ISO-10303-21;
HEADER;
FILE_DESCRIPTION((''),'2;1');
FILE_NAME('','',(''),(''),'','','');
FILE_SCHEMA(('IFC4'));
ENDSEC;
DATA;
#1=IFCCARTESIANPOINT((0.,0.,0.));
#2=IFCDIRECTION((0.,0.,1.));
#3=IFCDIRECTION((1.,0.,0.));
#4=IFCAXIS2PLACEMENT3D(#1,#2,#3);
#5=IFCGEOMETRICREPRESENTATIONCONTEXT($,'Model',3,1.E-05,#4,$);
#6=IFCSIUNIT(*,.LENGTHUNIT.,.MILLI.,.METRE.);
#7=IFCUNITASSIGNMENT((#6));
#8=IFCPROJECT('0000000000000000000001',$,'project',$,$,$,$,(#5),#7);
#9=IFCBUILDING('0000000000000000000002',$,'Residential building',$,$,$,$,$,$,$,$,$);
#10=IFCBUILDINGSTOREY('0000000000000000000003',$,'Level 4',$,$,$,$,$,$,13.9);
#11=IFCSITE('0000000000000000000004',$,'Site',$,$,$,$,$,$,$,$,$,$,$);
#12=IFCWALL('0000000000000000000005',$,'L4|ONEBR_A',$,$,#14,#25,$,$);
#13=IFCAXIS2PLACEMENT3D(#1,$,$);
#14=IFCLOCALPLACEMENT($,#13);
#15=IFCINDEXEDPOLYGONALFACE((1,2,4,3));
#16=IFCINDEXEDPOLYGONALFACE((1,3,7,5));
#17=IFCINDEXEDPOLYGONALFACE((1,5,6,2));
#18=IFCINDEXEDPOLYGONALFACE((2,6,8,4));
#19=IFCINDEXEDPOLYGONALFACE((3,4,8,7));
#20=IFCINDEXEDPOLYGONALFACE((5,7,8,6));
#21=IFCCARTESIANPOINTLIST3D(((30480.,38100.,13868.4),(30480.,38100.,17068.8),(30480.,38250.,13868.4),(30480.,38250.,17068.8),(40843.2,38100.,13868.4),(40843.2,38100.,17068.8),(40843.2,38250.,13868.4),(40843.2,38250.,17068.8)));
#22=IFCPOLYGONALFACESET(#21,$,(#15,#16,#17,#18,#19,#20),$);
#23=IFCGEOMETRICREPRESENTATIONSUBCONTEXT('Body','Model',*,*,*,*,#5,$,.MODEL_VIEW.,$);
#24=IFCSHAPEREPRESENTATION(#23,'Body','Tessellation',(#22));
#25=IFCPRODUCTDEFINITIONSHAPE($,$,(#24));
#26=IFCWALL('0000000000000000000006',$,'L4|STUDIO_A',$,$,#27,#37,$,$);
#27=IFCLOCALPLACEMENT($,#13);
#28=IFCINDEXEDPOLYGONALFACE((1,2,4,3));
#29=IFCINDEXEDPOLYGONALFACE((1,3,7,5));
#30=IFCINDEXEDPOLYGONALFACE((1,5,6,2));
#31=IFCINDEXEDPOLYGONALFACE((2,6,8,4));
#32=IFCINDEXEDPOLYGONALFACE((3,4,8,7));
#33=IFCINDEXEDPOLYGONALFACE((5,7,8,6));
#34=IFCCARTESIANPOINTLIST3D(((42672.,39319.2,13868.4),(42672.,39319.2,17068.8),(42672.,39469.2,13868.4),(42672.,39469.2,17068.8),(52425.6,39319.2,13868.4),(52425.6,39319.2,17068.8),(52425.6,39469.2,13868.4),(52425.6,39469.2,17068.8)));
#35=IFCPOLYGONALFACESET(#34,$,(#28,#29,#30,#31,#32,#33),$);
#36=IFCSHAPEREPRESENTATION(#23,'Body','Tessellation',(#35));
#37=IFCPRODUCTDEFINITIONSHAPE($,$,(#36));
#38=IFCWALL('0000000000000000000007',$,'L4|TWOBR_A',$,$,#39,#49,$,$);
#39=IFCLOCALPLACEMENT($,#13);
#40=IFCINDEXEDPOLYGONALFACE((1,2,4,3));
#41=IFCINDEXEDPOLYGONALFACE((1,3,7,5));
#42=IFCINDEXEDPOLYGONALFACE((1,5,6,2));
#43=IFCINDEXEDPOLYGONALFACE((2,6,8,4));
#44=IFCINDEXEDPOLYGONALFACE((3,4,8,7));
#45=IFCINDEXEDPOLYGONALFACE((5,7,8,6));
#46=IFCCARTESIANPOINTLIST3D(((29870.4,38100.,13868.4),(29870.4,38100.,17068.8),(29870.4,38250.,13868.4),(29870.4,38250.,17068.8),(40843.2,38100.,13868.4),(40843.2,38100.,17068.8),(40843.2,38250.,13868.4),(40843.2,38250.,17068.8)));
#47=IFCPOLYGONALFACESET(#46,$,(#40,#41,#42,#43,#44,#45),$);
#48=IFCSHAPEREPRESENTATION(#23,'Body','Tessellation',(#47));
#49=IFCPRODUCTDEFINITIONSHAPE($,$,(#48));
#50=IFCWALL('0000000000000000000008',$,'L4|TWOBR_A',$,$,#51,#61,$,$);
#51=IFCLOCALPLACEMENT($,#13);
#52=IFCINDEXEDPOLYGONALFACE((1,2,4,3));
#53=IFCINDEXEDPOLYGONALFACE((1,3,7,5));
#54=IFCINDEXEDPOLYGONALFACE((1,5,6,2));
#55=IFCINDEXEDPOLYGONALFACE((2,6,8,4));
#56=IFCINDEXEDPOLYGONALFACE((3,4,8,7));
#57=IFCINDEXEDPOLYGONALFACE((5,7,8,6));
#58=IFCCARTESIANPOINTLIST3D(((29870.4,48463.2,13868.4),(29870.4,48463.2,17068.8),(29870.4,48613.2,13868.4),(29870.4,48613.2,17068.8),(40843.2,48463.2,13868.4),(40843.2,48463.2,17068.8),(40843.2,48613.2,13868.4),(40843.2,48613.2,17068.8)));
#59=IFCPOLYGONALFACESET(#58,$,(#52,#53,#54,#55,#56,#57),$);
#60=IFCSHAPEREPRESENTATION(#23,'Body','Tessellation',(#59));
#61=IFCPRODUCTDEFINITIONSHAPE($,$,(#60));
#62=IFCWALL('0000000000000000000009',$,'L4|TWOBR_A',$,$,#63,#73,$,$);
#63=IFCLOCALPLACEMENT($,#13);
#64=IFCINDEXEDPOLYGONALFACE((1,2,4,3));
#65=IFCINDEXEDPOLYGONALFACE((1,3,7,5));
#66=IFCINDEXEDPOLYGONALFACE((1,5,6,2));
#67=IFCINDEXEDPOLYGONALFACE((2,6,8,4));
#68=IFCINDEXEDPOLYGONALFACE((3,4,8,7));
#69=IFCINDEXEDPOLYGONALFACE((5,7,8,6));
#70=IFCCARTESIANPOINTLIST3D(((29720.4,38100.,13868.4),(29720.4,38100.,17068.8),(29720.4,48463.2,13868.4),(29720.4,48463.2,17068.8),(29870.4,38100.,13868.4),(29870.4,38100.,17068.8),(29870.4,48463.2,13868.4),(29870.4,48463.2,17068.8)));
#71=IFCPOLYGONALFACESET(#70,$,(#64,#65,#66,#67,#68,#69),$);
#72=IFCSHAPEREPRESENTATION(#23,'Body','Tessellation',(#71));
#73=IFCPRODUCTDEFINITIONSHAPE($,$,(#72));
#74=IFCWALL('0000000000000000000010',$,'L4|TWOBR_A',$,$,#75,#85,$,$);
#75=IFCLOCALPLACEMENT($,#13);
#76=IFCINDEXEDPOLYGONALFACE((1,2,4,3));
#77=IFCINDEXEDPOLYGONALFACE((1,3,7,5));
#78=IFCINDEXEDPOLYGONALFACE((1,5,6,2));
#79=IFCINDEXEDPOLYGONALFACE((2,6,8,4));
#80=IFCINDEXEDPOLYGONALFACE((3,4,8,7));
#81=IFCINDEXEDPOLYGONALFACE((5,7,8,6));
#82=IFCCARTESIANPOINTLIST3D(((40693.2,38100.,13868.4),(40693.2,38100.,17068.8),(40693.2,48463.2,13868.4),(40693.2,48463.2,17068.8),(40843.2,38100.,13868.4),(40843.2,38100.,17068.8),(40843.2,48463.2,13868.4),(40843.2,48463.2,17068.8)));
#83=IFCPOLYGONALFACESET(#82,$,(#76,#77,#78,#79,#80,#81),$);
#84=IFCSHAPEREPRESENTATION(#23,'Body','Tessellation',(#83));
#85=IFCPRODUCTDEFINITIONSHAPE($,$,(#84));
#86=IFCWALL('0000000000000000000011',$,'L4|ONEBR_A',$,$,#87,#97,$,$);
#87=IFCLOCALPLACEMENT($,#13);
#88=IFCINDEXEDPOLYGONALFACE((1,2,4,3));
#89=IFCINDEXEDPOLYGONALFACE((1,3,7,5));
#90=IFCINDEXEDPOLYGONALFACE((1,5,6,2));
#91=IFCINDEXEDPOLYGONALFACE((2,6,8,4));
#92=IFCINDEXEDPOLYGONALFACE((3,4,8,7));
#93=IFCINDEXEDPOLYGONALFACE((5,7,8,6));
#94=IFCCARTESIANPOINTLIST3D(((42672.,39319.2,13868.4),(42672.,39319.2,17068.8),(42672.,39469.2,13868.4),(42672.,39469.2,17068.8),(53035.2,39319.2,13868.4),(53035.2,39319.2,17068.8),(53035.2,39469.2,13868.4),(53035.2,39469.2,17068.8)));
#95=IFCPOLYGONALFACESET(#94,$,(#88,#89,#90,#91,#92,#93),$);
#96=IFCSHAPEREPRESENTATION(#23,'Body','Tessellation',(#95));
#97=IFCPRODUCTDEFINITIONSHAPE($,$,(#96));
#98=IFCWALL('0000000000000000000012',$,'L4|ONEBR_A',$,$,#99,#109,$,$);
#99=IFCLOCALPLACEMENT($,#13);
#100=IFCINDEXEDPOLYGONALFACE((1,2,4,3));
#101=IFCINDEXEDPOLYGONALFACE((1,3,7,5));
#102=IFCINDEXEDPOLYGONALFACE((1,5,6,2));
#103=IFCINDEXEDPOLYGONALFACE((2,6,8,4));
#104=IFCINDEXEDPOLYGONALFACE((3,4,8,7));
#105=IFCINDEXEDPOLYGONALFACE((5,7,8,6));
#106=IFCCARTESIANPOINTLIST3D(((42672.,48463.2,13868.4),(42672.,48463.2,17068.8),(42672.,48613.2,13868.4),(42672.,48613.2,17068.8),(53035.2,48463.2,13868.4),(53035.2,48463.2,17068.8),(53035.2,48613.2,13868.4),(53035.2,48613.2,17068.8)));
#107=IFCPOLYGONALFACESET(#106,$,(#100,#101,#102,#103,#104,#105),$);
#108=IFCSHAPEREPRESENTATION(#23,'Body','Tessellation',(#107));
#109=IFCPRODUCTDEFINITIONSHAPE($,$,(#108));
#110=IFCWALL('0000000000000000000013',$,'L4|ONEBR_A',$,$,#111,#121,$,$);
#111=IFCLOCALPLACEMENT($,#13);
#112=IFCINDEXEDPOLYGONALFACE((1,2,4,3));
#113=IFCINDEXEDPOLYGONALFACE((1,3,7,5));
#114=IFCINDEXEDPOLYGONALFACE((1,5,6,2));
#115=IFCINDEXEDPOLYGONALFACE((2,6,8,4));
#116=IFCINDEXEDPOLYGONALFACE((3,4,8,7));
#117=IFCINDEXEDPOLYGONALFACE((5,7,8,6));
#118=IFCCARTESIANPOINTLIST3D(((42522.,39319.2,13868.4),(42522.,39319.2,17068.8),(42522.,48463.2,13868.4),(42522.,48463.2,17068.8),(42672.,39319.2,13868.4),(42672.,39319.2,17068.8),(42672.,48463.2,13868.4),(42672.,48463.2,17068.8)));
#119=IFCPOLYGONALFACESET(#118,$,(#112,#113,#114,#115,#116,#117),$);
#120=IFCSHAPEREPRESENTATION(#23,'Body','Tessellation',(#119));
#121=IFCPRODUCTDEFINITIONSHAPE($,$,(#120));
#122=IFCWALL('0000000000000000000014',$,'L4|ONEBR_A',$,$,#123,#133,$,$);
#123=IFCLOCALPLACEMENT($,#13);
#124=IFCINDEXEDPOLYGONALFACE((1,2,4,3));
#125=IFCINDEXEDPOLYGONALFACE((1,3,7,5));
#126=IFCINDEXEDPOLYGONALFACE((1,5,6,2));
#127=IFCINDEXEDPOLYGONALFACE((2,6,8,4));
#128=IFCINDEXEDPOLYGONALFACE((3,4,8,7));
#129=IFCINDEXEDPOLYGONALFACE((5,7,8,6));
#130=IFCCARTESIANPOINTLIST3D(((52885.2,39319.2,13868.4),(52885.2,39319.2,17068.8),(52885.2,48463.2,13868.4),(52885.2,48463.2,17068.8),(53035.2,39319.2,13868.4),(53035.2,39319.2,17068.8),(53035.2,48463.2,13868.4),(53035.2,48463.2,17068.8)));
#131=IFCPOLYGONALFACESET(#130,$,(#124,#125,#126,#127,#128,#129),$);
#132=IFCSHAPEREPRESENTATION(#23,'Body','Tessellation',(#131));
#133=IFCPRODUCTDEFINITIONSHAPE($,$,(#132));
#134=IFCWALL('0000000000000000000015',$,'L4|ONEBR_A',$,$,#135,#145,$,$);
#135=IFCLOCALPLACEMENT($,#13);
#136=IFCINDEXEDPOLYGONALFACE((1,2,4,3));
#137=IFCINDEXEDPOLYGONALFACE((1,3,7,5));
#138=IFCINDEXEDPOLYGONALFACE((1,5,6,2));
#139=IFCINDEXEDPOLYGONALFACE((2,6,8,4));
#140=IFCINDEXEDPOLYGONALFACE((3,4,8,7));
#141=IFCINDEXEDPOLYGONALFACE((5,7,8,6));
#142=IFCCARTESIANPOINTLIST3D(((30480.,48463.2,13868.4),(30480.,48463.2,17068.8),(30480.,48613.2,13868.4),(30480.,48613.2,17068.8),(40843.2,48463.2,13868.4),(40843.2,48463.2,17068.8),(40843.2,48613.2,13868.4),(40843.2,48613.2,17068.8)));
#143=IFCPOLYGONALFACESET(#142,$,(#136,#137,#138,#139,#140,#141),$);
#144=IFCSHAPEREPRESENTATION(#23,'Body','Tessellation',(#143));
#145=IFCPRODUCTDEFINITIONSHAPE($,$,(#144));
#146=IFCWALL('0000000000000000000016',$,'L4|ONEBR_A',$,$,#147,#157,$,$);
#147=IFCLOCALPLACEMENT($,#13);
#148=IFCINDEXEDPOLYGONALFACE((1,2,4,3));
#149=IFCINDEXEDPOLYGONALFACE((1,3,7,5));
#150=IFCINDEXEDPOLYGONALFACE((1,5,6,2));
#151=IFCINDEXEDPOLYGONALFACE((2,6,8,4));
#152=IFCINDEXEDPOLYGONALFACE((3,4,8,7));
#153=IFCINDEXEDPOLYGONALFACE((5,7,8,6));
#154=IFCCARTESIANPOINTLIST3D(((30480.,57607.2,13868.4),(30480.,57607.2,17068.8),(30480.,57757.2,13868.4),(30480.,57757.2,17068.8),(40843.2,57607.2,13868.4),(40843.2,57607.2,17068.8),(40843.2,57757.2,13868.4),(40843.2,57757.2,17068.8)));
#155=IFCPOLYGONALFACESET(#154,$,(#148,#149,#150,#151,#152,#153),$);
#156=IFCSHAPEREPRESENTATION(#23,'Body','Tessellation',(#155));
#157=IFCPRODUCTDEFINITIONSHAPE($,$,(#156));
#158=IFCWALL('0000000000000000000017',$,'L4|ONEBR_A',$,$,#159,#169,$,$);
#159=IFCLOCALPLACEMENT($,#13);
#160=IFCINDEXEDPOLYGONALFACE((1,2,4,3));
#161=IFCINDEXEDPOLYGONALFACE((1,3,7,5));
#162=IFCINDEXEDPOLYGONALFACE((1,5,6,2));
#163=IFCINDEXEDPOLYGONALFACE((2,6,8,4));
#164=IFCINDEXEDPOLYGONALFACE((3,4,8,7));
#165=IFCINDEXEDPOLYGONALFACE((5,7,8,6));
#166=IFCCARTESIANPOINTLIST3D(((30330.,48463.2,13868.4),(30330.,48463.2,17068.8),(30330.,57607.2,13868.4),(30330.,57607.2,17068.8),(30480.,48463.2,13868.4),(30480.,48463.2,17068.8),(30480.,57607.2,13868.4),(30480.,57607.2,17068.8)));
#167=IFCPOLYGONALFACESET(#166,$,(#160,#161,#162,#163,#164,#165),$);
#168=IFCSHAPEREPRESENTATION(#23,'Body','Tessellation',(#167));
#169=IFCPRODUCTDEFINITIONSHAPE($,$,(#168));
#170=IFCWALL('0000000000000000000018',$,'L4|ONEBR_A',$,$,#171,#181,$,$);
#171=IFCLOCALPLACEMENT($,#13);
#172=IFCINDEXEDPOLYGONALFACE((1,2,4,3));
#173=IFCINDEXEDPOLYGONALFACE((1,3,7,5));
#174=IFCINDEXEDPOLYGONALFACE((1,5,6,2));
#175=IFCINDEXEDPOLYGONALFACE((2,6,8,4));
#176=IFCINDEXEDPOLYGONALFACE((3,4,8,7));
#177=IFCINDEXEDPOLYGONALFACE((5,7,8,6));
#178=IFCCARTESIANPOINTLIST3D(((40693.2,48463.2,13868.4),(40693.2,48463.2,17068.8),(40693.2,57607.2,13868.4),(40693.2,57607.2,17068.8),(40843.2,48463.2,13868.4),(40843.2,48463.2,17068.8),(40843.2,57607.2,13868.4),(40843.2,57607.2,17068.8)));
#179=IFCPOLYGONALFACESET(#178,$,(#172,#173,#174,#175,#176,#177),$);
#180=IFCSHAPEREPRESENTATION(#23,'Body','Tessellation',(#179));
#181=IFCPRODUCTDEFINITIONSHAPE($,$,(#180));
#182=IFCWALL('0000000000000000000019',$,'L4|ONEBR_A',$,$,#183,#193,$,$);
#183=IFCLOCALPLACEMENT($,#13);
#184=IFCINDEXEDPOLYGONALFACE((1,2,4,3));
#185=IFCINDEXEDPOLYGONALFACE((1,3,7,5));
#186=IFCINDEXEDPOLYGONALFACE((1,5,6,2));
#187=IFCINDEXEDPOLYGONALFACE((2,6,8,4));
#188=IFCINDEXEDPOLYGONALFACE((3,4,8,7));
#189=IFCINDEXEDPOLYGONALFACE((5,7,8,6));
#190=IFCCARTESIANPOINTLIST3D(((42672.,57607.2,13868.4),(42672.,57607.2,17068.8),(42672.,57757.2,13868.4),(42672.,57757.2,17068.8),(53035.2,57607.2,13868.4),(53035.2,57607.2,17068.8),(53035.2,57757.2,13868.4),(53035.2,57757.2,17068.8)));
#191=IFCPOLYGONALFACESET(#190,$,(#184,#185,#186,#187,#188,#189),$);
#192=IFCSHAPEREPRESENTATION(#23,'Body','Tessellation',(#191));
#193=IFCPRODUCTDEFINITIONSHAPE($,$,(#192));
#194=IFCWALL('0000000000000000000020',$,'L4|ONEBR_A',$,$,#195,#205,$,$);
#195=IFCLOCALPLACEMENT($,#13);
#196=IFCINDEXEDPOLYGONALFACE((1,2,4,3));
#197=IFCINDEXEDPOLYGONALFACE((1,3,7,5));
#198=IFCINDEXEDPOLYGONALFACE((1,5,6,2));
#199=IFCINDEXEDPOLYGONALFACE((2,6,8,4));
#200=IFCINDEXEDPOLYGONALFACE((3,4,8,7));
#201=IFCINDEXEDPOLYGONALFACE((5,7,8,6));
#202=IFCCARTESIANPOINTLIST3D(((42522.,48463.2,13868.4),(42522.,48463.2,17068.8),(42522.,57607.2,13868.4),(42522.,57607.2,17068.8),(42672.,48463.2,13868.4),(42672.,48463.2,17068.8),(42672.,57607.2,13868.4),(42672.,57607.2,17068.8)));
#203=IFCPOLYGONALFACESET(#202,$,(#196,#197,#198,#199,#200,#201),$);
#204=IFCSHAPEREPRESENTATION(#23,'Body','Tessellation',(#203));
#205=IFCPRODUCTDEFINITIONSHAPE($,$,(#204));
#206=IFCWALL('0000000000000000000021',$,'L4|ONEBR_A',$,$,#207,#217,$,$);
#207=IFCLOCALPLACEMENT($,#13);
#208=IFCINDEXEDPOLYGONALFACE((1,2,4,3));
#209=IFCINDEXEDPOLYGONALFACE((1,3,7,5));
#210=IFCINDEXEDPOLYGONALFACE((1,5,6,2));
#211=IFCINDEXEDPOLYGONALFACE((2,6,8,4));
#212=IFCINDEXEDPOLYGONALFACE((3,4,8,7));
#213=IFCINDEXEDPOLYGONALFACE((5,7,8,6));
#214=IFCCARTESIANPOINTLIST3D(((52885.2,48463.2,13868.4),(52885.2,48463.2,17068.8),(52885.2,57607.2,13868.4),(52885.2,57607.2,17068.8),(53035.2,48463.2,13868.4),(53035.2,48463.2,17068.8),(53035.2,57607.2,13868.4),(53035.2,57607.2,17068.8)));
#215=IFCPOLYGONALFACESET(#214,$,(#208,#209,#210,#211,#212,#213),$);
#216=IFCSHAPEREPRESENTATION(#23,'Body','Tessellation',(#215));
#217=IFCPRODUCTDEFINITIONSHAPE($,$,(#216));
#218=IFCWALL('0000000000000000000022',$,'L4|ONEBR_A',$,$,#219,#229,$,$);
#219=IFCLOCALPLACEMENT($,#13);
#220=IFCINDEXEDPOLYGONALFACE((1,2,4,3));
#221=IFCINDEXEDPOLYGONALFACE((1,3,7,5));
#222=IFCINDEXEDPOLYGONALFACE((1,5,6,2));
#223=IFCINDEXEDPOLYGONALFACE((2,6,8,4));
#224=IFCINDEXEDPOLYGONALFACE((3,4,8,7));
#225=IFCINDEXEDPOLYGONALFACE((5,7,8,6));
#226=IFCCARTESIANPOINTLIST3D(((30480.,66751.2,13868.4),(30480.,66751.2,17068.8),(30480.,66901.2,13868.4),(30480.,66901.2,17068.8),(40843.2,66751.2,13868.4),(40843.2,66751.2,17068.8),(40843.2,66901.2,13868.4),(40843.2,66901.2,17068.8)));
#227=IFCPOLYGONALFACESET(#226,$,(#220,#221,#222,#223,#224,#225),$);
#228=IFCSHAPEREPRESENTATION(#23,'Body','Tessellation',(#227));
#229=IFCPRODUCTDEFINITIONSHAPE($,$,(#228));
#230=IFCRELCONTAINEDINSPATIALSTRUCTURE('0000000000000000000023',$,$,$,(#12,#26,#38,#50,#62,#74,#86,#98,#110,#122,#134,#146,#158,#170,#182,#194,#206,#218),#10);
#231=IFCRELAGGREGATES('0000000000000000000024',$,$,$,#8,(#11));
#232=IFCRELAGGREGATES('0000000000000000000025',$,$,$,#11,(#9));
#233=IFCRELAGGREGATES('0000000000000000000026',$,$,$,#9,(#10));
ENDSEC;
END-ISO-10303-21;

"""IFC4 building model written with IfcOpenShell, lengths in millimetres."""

from ifc_helpers import new_model, si_unit, frame, origin_with_axes, place, context, subcontext, project, spatial, indexed_curve, outline, extrude, element, save


model = new_model("IFC4")

# Units and contexts
model_context = context("Model", 3, precision=1e-05, world=origin_with_axes())
body_context = subcontext(model_context, "Body", "Model", "MODEL_VIEW")
ifc_project = project(units=[si_unit("LENGTHUNIT", "METRE", prefix="MILLI")], contexts=[model_context])

# Site, building, storey
site = spatial("IfcSite", under=ifc_project, Name="Site")
building = spatial("IfcBuilding", under=site, Name="Residential building")
storey = spatial("IfcBuildingStorey", under=building, Name="Level 4", Elevation=13.9)

# Walls
wall_1_placement = place(None, frame((30480.0, 38100.0, 13868.4), z_axis=(0.0, 0.0, 1.0), x_axis=(1.0, 0.0, 0.0)))
element("IfcWall", 1, at=wall_1_placement, inside=storey, Name="L4|ONEBR_A", context=body_context, shape_type="SweptSolid", body=[
    extrude(outline(indexed_curve([(0.0, 0.0), (0.0, 150.0), (10363.2, 150.0), (10363.2, 0.0), (0.0, 0.0)], self_intersect=False)), origin_with_axes(), (0.0, 0.0, 1.0), 3200.4),
])
wall_2_placement = place(None, frame((42672.0, 39319.2, 13868.4), z_axis=(0.0, 0.0, 1.0), x_axis=(1.0, 0.0, 0.0)))
element("IfcWall", 2, at=wall_2_placement, inside=storey, Name="L4|STUDIO_A", context=body_context, shape_type="SweptSolid", body=[
    extrude(outline(indexed_curve([(0.0, 0.0), (0.0, 150.0), (9753.6, 150.0), (9753.6, 0.0), (0.0, 0.0)], self_intersect=False)), origin_with_axes(), (0.0, 0.0, 1.0), 3200.4),
])
for number, where, z_axis, x_axis, name in (
    (3, (29870.4, 38100.0, 13868.4), (0.0, 0.0, 1.0), (1.0, 0.0, 0.0), "L4|TWOBR_A"),
    (4, (29870.4, 48463.2, 13868.4), (0.0, 0.0, 1.0), (1.0, 0.0, 0.0), "L4|TWOBR_A"),
):
    element("IfcWall", number, at=place(None, frame(where, z_axis=z_axis, x_axis=x_axis)), inside=storey, Name=name, context=body_context, shape_type="SweptSolid", body=[
        extrude(outline(indexed_curve([(0.0, 0.0), (0.0, 150.0), (10972.8, 150.0), (10972.8, 0.0), (0.0, 0.0)], self_intersect=False)), origin_with_axes(), (0.0, 0.0, 1.0), 3200.4),
    ])
for number, where, z_axis, x_axis, name in (
    (5, (29870.4, 38100.0, 13868.4), (0.0, 0.0, 1.0), (0.0, 1.0, 0.0), "L4|TWOBR_A"),
    (6, (40843.2, 38100.0, 13868.4), (0.0, 0.0, 1.0), (0.0, 1.0, 0.0), "L4|TWOBR_A"),
    (7, (42672.0, 39319.2, 13868.4), (0.0, 0.0, 1.0), (1.0, 0.0, 0.0), "L4|ONEBR_A"),
    (8, (42672.0, 48463.2, 13868.4), (0.0, 0.0, 1.0), (1.0, 0.0, 0.0), "L4|ONEBR_A"),
):
    element("IfcWall", number, at=place(None, frame(where, z_axis=z_axis, x_axis=x_axis)), inside=storey, Name=name, context=body_context, shape_type="SweptSolid", body=[
        extrude(outline(indexed_curve([(0.0, 0.0), (0.0, 150.0), (10363.2, 150.0), (10363.2, 0.0), (0.0, 0.0)], self_intersect=False)), origin_with_axes(), (0.0, 0.0, 1.0), 3200.4),
    ])
for number, where, z_axis, x_axis, name in (
    (9, (42672.0, 39319.2, 13868.4), (0.0, 0.0, 1.0), (0.0, 1.0, 0.0), "L4|ONEBR_A"),
    (10, (53035.2, 39319.2, 13868.4), (0.0, 0.0, 1.0), (0.0, 1.0, 0.0), "L4|ONEBR_A"),
):
    element("IfcWall", number, at=place(None, frame(where, z_axis=z_axis, x_axis=x_axis)), inside=storey, Name=name, context=body_context, shape_type="SweptSolid", body=[
        extrude(outline(indexed_curve([(0.0, 0.0), (0.0, 150.0), (9144.0, 150.0), (9144.0, 0.0), (0.0, 0.0)], self_intersect=False)), origin_with_axes(), (0.0, 0.0, 1.0), 3200.4),
    ])
for number, where, z_axis, x_axis, name in (
    (11, (30480.0, 48463.2, 13868.4), (0.0, 0.0, 1.0), (1.0, 0.0, 0.0), "L4|ONEBR_A"),
    (12, (30480.0, 57607.2, 13868.4), (0.0, 0.0, 1.0), (1.0, 0.0, 0.0), "L4|ONEBR_A"),
):
    element("IfcWall", number, at=place(None, frame(where, z_axis=z_axis, x_axis=x_axis)), inside=storey, Name=name, context=body_context, shape_type="SweptSolid", body=[
        extrude(outline(indexed_curve([(0.0, 0.0), (0.0, 150.0), (10363.2, 150.0), (10363.2, 0.0), (0.0, 0.0)], self_intersect=False)), origin_with_axes(), (0.0, 0.0, 1.0), 3200.4),
    ])
for number, where, z_axis, x_axis, name in (
    (13, (30480.0, 48463.2, 13868.4), (0.0, 0.0, 1.0), (0.0, 1.0, 0.0), "L4|ONEBR_A"),
    (14, (40843.2, 48463.2, 13868.4), (0.0, 0.0, 1.0), (0.0, 1.0, 0.0), "L4|ONEBR_A"),
):
    element("IfcWall", number, at=place(None, frame(where, z_axis=z_axis, x_axis=x_axis)), inside=storey, Name=name, context=body_context, shape_type="SweptSolid", body=[
        extrude(outline(indexed_curve([(0.0, 0.0), (0.0, 150.0), (9144.0, 150.0), (9144.0, 0.0), (0.0, 0.0)], self_intersect=False)), origin_with_axes(), (0.0, 0.0, 1.0), 3200.4),
    ])
for number, where, z_axis, x_axis, name in (
    (15, (42672.0, 57607.2, 13868.4), (0.0, 0.0, 1.0), (1.0, 0.0, 0.0), "L4|ONEBR_A"),
):
    element("IfcWall", number, at=place(None, frame(where, z_axis=z_axis, x_axis=x_axis)), inside=storey, Name=name, context=body_context, shape_type="SweptSolid", body=[
        extrude(outline(indexed_curve([(0.0, 0.0), (0.0, 150.0), (10363.2, 150.0), (10363.2, 0.0), (0.0, 0.0)], self_intersect=False)), origin_with_axes(), (0.0, 0.0, 1.0), 3200.4),
    ])
for number, where, z_axis, x_axis, name in (
    (16, (42672.0, 48463.2, 13868.4), (0.0, 0.0, 1.0), (0.0, 1.0, 0.0), "L4|ONEBR_A"),
    (17, (53035.2, 48463.2, 13868.4), (0.0, 0.0, 1.0), (0.0, 1.0, 0.0), "L4|ONEBR_A"),
):
    element("IfcWall", number, at=place(None, frame(where, z_axis=z_axis, x_axis=x_axis)), inside=storey, Name=name, context=body_context, shape_type="SweptSolid", body=[
        extrude(outline(indexed_curve([(0.0, 0.0), (0.0, 150.0), (9144.0, 150.0), (9144.0, 0.0), (0.0, 0.0)], self_intersect=False)), origin_with_axes(), (0.0, 0.0, 1.0), 3200.4),
    ])
for number, where, z_axis, x_axis, name in (
    (18, (30480.0, 66751.2, 13868.4), (0.0, 0.0, 1.0), (1.0, 0.0, 0.0), "L4|ONEBR_A"),
):
    element("IfcWall", number, at=place(None, frame(where, z_axis=z_axis, x_axis=x_axis)), inside=storey, Name=name, context=body_context, shape_type="SweptSolid", body=[
        extrude(outline(indexed_curve([(0.0, 0.0), (0.0, 150.0), (10363.2, 150.0), (10363.2, 0.0), (0.0, 0.0)], self_intersect=False)), origin_with_axes(), (0.0, 0.0, 1.0), 3200.4),
    ])

save(model, "model.ifc")
